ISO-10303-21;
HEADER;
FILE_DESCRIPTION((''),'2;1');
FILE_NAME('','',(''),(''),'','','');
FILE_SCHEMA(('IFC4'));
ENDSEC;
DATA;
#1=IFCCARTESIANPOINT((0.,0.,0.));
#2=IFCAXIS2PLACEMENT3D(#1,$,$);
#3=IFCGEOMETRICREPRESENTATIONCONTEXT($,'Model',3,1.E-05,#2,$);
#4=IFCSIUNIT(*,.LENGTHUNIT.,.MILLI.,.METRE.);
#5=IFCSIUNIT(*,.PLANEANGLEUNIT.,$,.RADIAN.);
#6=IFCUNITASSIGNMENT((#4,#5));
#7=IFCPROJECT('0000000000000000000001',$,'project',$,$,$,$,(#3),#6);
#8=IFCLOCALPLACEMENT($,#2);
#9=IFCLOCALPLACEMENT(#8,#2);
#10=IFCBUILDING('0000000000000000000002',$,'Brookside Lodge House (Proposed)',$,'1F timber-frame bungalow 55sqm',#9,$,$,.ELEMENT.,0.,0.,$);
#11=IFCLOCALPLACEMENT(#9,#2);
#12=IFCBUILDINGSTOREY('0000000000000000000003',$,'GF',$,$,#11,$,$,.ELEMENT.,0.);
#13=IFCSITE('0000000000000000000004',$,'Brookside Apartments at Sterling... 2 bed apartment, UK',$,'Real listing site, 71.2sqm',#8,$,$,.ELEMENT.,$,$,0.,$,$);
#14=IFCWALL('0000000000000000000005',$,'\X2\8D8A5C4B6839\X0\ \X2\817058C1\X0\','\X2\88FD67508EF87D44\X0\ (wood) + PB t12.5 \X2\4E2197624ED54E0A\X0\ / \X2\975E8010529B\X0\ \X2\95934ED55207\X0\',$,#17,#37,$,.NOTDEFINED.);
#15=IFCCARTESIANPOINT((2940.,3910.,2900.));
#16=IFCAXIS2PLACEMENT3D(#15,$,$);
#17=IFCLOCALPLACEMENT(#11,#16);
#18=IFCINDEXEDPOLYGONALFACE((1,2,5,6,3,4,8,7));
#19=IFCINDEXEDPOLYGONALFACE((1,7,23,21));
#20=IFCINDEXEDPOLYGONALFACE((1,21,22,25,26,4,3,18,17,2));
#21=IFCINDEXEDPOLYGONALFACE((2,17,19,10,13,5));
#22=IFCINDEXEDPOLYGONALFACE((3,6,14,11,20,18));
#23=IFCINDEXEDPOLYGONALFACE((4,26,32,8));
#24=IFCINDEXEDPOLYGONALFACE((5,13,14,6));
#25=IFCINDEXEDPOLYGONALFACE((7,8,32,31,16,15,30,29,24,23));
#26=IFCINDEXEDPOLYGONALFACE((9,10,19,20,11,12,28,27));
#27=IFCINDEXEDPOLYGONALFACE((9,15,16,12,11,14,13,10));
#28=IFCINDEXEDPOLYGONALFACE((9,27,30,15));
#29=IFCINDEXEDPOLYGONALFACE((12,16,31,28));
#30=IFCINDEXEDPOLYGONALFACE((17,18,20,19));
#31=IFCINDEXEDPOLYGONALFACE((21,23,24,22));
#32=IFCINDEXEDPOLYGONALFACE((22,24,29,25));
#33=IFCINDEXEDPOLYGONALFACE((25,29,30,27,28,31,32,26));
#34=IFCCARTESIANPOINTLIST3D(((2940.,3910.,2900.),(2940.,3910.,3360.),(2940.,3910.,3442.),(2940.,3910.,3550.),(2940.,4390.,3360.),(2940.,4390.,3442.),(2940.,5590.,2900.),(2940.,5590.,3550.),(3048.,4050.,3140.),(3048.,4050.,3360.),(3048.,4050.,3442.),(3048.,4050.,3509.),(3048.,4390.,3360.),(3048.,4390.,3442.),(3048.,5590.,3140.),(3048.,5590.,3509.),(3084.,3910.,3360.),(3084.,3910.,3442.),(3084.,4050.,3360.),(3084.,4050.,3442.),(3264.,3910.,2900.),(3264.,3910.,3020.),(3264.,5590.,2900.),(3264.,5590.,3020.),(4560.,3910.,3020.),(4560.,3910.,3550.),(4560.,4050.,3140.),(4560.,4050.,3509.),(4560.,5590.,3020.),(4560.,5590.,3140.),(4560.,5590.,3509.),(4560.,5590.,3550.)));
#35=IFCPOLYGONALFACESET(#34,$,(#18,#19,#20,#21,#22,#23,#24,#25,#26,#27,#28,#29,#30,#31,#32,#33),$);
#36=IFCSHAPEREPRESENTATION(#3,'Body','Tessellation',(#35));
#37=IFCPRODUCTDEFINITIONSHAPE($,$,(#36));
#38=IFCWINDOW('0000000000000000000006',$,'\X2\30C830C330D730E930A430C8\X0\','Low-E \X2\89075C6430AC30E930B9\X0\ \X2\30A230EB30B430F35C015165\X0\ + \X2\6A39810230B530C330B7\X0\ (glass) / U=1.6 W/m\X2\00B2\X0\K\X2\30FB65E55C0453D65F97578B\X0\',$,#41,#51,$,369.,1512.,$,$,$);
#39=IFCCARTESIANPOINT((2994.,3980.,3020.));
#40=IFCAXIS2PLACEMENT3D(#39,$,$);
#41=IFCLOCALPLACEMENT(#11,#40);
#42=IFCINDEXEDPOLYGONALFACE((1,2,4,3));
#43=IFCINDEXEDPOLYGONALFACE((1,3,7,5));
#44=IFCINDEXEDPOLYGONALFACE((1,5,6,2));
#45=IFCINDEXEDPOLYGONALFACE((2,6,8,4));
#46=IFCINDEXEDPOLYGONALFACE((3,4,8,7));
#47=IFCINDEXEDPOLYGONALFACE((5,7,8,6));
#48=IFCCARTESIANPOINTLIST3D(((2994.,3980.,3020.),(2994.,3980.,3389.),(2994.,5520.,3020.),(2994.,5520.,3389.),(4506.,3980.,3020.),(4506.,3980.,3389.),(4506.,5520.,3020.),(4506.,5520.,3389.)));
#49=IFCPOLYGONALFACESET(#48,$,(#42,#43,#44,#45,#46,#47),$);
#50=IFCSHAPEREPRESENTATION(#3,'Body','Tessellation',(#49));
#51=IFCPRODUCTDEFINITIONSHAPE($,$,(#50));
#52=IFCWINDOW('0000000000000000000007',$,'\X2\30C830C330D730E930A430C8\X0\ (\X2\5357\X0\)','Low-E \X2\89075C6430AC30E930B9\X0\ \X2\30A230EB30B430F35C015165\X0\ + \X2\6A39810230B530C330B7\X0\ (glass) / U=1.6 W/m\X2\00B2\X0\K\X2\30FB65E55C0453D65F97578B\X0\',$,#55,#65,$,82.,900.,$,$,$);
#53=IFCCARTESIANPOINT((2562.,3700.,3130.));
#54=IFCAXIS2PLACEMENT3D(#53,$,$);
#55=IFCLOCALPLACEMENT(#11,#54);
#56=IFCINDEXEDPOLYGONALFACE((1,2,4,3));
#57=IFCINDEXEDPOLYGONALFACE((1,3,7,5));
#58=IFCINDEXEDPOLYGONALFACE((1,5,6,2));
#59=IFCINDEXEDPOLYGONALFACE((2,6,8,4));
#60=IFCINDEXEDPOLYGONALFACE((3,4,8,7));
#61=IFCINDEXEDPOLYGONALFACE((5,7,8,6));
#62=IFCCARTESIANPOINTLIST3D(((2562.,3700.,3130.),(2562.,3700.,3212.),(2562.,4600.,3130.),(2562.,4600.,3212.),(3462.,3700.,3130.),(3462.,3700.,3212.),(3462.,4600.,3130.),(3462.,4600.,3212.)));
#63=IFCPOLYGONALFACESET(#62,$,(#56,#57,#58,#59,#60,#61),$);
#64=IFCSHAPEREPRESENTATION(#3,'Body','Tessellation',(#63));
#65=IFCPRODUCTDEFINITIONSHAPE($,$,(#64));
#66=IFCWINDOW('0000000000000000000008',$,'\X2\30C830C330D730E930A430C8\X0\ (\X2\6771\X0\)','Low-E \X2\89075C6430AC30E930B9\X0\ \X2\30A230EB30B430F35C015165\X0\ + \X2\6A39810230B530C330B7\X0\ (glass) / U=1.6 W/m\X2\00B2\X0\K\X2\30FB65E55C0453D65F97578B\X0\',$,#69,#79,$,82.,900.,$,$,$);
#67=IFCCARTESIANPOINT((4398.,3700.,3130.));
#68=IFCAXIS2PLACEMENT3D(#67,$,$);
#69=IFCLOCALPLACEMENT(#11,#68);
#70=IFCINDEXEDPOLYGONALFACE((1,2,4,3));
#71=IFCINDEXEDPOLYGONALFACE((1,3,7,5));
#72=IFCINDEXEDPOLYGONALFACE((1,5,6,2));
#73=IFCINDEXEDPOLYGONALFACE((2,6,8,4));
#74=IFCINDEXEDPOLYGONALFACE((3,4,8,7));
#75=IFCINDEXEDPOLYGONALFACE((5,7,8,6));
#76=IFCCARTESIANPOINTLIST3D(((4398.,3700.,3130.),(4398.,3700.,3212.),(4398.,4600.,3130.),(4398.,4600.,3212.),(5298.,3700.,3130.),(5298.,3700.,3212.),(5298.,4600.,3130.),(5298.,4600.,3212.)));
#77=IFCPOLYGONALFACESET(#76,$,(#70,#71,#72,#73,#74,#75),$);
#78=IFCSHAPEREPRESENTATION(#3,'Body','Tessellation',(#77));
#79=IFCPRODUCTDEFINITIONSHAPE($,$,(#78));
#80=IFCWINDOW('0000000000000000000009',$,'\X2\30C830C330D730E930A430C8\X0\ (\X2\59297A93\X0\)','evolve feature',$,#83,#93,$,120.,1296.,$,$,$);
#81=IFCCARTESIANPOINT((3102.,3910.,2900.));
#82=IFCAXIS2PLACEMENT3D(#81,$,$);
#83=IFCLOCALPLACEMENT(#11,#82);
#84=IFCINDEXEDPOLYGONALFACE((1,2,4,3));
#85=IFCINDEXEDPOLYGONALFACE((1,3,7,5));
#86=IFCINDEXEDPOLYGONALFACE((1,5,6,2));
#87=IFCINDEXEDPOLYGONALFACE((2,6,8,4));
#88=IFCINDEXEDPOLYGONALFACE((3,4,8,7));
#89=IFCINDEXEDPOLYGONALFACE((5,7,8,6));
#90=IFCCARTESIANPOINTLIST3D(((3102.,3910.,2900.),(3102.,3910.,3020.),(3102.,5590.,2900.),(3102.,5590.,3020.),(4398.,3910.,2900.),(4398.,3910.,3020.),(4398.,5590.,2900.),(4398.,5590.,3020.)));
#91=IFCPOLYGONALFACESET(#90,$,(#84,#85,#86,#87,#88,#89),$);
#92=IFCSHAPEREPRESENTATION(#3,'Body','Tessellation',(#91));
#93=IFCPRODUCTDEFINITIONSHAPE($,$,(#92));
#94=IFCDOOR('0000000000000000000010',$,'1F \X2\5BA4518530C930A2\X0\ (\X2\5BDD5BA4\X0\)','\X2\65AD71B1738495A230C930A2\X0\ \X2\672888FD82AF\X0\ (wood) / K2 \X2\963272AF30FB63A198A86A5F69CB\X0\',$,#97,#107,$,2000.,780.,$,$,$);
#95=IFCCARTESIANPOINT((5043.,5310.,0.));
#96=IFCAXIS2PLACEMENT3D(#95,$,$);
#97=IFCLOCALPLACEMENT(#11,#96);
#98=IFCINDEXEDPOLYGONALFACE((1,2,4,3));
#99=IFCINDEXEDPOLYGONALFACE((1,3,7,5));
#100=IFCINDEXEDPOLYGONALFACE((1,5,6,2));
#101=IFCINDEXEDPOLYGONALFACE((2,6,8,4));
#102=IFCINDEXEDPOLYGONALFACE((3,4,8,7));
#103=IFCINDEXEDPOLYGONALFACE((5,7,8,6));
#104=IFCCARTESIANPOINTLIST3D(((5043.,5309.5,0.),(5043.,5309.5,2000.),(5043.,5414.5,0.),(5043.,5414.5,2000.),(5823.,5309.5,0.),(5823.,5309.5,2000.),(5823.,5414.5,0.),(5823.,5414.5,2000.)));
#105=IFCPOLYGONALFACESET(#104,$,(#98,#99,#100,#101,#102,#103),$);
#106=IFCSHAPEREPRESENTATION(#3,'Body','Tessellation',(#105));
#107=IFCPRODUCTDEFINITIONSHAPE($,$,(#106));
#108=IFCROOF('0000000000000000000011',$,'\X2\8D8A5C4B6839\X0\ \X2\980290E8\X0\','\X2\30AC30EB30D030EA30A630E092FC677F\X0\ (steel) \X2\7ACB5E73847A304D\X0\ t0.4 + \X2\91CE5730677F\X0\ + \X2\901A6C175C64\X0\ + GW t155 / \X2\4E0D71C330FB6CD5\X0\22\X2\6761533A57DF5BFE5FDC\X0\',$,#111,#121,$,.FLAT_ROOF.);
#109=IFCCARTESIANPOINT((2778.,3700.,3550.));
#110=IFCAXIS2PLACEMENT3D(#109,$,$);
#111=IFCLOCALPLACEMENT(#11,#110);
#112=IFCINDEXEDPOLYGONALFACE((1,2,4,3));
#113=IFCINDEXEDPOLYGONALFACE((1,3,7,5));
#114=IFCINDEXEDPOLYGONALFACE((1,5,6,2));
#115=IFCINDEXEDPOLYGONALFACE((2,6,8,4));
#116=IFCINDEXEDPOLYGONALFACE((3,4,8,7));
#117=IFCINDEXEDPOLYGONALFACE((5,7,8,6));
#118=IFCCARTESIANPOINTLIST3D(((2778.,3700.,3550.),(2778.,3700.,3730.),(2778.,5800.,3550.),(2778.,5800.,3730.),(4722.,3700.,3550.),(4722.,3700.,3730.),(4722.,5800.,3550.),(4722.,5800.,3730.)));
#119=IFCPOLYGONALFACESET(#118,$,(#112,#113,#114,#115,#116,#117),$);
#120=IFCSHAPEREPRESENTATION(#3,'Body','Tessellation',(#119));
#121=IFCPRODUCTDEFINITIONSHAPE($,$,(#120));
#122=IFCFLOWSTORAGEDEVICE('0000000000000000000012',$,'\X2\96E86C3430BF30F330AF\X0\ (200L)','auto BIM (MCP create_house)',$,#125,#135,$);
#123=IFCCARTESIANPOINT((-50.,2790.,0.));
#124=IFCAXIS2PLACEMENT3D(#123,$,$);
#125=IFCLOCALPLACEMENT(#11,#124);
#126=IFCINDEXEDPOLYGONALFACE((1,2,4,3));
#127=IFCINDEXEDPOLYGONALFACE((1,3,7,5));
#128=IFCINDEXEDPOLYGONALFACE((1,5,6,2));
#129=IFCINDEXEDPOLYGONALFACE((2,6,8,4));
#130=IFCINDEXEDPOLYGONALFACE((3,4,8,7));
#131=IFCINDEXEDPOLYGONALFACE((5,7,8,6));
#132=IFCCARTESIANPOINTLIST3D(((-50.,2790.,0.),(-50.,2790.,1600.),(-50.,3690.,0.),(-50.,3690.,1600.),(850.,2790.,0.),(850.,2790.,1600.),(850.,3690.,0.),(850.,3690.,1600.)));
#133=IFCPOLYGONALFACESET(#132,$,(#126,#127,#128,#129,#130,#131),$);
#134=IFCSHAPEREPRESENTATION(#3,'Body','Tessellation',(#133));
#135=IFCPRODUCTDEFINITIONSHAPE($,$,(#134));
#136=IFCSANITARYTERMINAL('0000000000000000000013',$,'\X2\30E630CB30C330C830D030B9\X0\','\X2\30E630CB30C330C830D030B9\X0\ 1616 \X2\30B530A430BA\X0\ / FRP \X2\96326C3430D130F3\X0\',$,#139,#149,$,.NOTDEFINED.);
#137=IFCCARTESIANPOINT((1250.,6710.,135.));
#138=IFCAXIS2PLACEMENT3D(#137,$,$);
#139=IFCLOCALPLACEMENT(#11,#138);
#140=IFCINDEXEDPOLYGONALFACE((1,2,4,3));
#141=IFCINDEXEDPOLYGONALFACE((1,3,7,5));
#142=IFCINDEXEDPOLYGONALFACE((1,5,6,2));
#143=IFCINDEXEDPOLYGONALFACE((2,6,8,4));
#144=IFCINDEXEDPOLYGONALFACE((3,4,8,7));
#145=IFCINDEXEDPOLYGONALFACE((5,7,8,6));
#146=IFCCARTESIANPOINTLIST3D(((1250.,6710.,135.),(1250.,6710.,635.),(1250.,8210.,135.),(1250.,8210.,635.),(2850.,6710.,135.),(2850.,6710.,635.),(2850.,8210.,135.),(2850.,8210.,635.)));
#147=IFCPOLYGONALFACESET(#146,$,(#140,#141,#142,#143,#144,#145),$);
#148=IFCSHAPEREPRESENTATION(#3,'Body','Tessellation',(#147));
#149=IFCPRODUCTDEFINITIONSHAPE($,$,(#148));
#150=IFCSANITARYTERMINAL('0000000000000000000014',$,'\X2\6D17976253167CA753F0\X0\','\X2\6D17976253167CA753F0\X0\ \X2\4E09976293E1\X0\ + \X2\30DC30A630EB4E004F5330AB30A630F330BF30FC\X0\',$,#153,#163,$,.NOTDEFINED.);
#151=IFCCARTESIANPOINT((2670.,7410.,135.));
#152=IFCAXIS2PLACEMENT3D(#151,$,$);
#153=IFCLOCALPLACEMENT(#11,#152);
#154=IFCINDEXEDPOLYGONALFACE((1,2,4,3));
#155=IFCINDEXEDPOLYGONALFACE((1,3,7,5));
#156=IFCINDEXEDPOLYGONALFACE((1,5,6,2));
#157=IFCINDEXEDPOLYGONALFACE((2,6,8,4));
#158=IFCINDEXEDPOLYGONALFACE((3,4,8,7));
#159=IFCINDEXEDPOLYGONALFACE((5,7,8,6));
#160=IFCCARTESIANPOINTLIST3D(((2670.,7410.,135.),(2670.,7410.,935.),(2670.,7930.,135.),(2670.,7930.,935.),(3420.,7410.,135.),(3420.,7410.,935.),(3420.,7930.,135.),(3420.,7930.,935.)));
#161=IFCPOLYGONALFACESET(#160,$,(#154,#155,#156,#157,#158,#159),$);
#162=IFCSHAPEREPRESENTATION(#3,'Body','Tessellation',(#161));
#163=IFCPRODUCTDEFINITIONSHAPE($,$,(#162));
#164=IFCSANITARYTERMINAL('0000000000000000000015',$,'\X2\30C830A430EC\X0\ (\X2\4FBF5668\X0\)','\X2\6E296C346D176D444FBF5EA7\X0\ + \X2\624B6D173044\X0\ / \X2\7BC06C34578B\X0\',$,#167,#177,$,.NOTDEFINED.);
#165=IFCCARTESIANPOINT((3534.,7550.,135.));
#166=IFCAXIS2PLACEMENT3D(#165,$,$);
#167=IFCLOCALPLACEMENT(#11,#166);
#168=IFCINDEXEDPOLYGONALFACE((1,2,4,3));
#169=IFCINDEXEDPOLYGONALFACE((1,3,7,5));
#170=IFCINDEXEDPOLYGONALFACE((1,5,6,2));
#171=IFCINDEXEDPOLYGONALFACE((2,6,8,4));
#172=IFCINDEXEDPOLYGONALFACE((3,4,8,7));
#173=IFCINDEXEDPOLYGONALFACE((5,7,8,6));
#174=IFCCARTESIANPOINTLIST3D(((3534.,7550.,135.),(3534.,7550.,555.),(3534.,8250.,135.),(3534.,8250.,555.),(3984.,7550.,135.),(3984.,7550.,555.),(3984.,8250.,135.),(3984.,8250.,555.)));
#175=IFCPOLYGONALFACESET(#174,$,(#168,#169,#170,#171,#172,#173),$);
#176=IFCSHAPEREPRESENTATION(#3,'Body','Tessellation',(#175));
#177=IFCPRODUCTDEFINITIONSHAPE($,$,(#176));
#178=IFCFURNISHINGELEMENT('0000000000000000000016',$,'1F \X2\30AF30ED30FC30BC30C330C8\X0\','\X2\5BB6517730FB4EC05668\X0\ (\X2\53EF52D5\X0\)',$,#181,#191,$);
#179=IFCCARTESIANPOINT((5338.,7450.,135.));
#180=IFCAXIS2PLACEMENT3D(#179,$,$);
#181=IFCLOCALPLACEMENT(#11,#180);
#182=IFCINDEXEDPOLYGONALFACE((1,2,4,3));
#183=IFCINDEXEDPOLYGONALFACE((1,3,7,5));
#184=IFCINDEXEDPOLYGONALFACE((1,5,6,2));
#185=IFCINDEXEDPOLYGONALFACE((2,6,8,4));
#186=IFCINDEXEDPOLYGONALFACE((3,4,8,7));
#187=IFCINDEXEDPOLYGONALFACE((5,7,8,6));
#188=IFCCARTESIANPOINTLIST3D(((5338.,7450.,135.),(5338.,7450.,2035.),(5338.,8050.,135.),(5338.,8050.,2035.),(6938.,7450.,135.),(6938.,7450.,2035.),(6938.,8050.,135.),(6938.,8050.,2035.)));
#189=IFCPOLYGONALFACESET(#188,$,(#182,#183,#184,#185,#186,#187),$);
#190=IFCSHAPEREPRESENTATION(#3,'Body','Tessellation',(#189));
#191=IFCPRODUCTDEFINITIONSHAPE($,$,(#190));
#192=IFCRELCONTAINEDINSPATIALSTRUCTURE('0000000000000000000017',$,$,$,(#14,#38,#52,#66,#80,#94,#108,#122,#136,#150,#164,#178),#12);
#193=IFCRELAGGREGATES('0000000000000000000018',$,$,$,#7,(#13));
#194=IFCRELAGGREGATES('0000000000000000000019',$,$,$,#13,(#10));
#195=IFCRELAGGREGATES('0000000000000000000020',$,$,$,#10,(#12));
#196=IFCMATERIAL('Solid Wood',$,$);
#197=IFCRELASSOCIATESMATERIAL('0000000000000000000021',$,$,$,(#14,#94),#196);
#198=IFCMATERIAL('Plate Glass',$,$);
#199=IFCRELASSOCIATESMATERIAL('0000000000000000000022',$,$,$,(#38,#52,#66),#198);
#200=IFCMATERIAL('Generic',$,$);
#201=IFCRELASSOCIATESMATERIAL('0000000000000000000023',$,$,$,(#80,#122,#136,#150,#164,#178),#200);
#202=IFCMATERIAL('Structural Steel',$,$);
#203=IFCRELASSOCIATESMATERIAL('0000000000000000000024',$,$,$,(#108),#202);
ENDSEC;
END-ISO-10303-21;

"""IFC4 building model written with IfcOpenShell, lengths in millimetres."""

from ifc_helpers import new_model, si_unit, frame, frame_2d, origin, place, context, project, spatial, rectangle, extrude, material, element, fill, save


model = new_model("IFC4")

# Units and contexts
model_context = context("Model", 3, precision=1e-05, world=origin())
ifc_project = project(units=[si_unit("LENGTHUNIT", "METRE", prefix="MILLI"), si_unit("PLANEANGLEUNIT", "RADIAN")], contexts=[model_context])

# Site, building, storey
site_placement = place(None, origin())
site = spatial("IfcSite", under=ifc_project, at=site_placement, Name="Brookside Apartments at Sterling... 2 bed apartment, UK", ObjectType="Real listing site, 71.2sqm", CompositionType="ELEMENT", RefElevation=0.0)
building_placement = place(site_placement, origin())
building = spatial("IfcBuilding", under=site, at=building_placement, Name="Brookside Lodge House (Proposed)", ObjectType="1F timber-frame bungalow 55sqm", CompositionType="ELEMENT", ElevationOfRefHeight=0.0, ElevationOfTerrain=0.0)
storey_placement = place(building_placement, origin())
storey = spatial("IfcBuildingStorey", under=building, at=storey_placement, Name="GF", CompositionType="ELEMENT", Elevation=0.0)

# Shared definitions
ifc_material_1 = material(Name="Solid Wood")

# Shared definitions
ifc_material_2 = material(Name="Plate Glass")

# Wall, openings, windows
wall_1_placement = place(storey_placement, frame((2940.0, 3910.0, 2900.0)))
wall_1 = element("IfcWall", 1, at=wall_1_placement, inside=storey, material=ifc_material_1, Name="越屋根 腰壁", Description="製材軸組 (wood) + PB t12.5 両面仕上 / 非耐力 間仕切", PredefinedType="NOTDEFINED", context=model_context, shape_type="SweptSolid", body=[
    extrude(rectangle(XDim=1620.0, YDim=1680.0, at=frame_2d((810.0, 840.0))), frame((2940.0, 3910.0, 2900.0)), (0.0, 0.0, 1.0), 650.0),
])
opening_1_placement = place(storey_placement, frame((2994.0, 3980.0, 3020.0)))
opening_1 = element("IfcOpeningElement", 2, at=opening_1_placement, cuts=wall_1, PredefinedType="NOTDEFINED", context=model_context, shape_type="SweptSolid", body=[
    extrude(rectangle(XDim=1512.0, YDim=1540.0, at=frame_2d((756.0, 770.0))), frame((2994.0, 3980.0, 3020.0)), (0.0, 0.0, 1.0), 369.0),
])
opening_2_placement = place(storey_placement, frame((2562.0, 3700.0, 3130.0)))
opening_2 = element("IfcOpeningElement", 3, at=opening_2_placement, cuts=wall_1, PredefinedType="NOTDEFINED", context=model_context, shape_type="SweptSolid", body=[
    extrude(rectangle(XDim=900.0, YDim=900.0, at=frame_2d((450.0, 450.0))), frame((2562.0, 3700.0, 3130.0)), (0.0, 0.0, 1.0), 82.0),
])
opening_3_placement = place(storey_placement, frame((4398.0, 3700.0, 3130.0)))
opening_3 = element("IfcOpeningElement", 4, at=opening_3_placement, cuts=wall_1, PredefinedType="NOTDEFINED", context=model_context, shape_type="SweptSolid", body=[
    extrude(rectangle(XDim=900.0, YDim=900.0, at=frame_2d((450.0, 450.0))), frame((4398.0, 3700.0, 3130.0)), (0.0, 0.0, 1.0), 82.0),
])
opening_4_placement = place(storey_placement, frame((3102.0, 3910.0, 2900.0)))
opening_4 = element("IfcOpeningElement", 5, at=opening_4_placement, cuts=wall_1, PredefinedType="NOTDEFINED", context=model_context, shape_type="SweptSolid", body=[
    extrude(rectangle(XDim=1296.0, YDim=1680.0, at=frame_2d((648.0, 840.0))), frame((3102.0, 3910.0, 2900.0)), (0.0, 0.0, 1.0), 120.0),
])
window_1_placement = place(storey_placement, frame((2994.0, 3980.0, 3020.0)))
window_1 = element("IfcWindow", 6, at=window_1_placement, inside=storey, material=ifc_material_2, Name="トップライト", Description="Low-E 複層ガラス アルゴン封入 + 樹脂サッシ (glass) / U=1.6 W/m²K・日射取得型", OverallHeight=369.0, OverallWidth=1512.0, context=model_context, shape_type="SweptSolid", body=[
    extrude(rectangle(XDim=1512.0, YDim=1540.0, at=frame_2d((756.0, 770.0))), frame((2994.0, 3980.0, 3020.0)), (0.0, 0.0, 1.0), 369.0),
])
fill(opening_1, window_1)
window_2_placement = place(storey_placement, frame((2562.0, 3700.0, 3130.0)))
window_2 = element("IfcWindow", 7, at=window_2_placement, inside=storey, material=ifc_material_2, Name="トップライト (南)", Description="Low-E 複層ガラス アルゴン封入 + 樹脂サッシ (glass) / U=1.6 W/m²K・日射取得型", OverallHeight=82.0, OverallWidth=900.0, context=model_context, shape_type="SweptSolid", body=[
    extrude(rectangle(XDim=900.0, YDim=900.0, at=frame_2d((450.0, 450.0))), frame((2562.0, 3700.0, 3130.0)), (0.0, 0.0, 1.0), 82.0),
])
fill(opening_2, window_2)
window_3_placement = place(storey_placement, frame((4398.0, 3700.0, 3130.0)))
window_3 = element("IfcWindow", 8, at=window_3_placement, inside=storey, material=ifc_material_2, Name="トップライト (東)", Description="Low-E 複層ガラス アルゴン封入 + 樹脂サッシ (glass) / U=1.6 W/m²K・日射取得型", OverallHeight=82.0, OverallWidth=900.0, context=model_context, shape_type="SweptSolid", body=[
    extrude(rectangle(XDim=900.0, YDim=900.0, at=frame_2d((450.0, 450.0))), frame((4398.0, 3700.0, 3130.0)), (0.0, 0.0, 1.0), 82.0),
])
fill(opening_3, window_3)
ifc_material_3 = material(Name="Generic")
window_4_placement = place(storey_placement, frame((3102.0, 3910.0, 2900.0)))
window_4 = element("IfcWindow", 9, at=window_4_placement, inside=storey, material=ifc_material_3, Name="トップライト (天窓)", Description="evolve feature", OverallHeight=120.0, OverallWidth=1296.0, context=model_context, shape_type="SweptSolid", body=[
    extrude(rectangle(XDim=1296.0, YDim=1680.0, at=frame_2d((648.0, 840.0))), frame((3102.0, 3910.0, 2900.0)), (0.0, 0.0, 1.0), 120.0),
])
fill(opening_4, window_4)

# Door
door_1_placement = place(storey_placement, frame((5043.0, 5310.0, 0.0)))
element("IfcDoor", 10, at=door_1_placement, inside=storey, material=ifc_material_1, Name="1F 室内ドア (寝室)", Description="断熱玄関ドア 木製芯 (wood) / K2 防犯・採風機構", OverallHeight=2000.0, OverallWidth=780.0, context=model_context, shape_type="SweptSolid", body=[
    extrude(rectangle(XDim=780.0, YDim=105.0, at=frame_2d((390.0, 52.0))), frame((5043.0, 5310.0, 0.0)), (0.0, 0.0, 1.0), 2000.0),
])

# Roof
ifc_material_4 = material(Name="Structural Steel")
roof_placement = place(storey_placement, frame((2778.0, 3700.0, 3550.0)))
element("IfcRoof", 11, at=roof_placement, inside=storey, material=ifc_material_4, Name="越屋根 頂部", Description="ガルバリウム鋼板 (steel) 立平葺き t0.4 + 野地板 + 通気層 + GW t155 / 不燃・法22条区域対応", PredefinedType="FLAT_ROOF", context=model_context, shape_type="SweptSolid", body=[
    extrude(rectangle(XDim=1944.0, YDim=2100.0, at=frame_2d((972.0, 1050.0))), frame((2778.0, 3700.0, 3550.0)), (0.0, 0.0, 1.0), 180.0),
])

# Flow storage device
flow_storage_device_placement = place(storey_placement, frame((-50.0, 2790.0, 0.0)))
element("IfcFlowStorageDevice", 12, at=flow_storage_device_placement, inside=storey, material=ifc_material_3, Name="雨水タンク (200L)", Description="auto BIM (MCP create_house)", context=model_context, shape_type="SweptSolid", body=[
    extrude(rectangle(XDim=900.0, YDim=900.0, at=frame_2d((450.0, 450.0))), frame((-50.0, 2790.0, 0.0)), (0.0, 0.0, 1.0), 1600.0),
])

# Sanitary terminals
sanitary_terminal_1_placement = place(storey_placement, frame((1250.0, 6710.0, 135.0)))
element("IfcSanitaryTerminal", 13, at=sanitary_terminal_1_placement, inside=storey, material=ifc_material_3, Name="ユニットバス", Description="ユニットバス 1616 サイズ / FRP 防水パン", PredefinedType="NOTDEFINED", context=model_context, shape_type="SweptSolid", body=[
    extrude(rectangle(XDim=1600.0, YDim=1500.0, at=frame_2d((800.0, 750.0))), frame((1250.0, 6710.0, 135.0)), (0.0, 0.0, 1.0), 500.0),
])
sanitary_terminal_2_placement = place(storey_placement, frame((2670.0, 7410.0, 135.0)))
element("IfcSanitaryTerminal", 14, at=sanitary_terminal_2_placement, inside=storey, material=ifc_material_3, Name="洗面化粧台", Description="洗面化粧台 三面鏡 + ボウル一体カウンター", PredefinedType="NOTDEFINED", context=model_context, shape_type="SweptSolid", body=[
    extrude(rectangle(XDim=750.0, YDim=520.0, at=frame_2d((375.0, 260.0))), frame((2670.0, 7410.0, 135.0)), (0.0, 0.0, 1.0), 800.0),
])
sanitary_terminal_3_placement = place(storey_placement, frame((3534.0, 7550.0, 135.0)))
element("IfcSanitaryTerminal", 15, at=sanitary_terminal_3_placement, inside=storey, material=ifc_material_3, Name="トイレ (便器)", Description="温水洗浄便座 + 手洗い / 節水型", PredefinedType="NOTDEFINED", context=model_context, shape_type="SweptSolid", body=[
    extrude(rectangle(XDim=450.0, YDim=700.0, at=frame_2d((225.0, 350.0))), frame((3534.0, 7550.0, 135.0)), (0.0, 0.0, 1.0), 420.0),
])

# Furnishing element
furnishing_1_placement = place(storey_placement, frame((5338.0, 7450.0, 135.0)))
element("IfcFurnishingElement", 16, at=furnishing_1_placement, inside=storey, material=ifc_material_3, Name="1F クローゼット", Description="家具・什器 (可動)", context=model_context, shape_type="SweptSolid", body=[
    extrude(rectangle(XDim=1600.0, YDim=600.0, at=frame_2d((800.0, 300.0))), frame((5338.0, 7450.0, 135.0)), (0.0, 0.0, 1.0), 1900.0),
])

save(model, "model.ifc")
